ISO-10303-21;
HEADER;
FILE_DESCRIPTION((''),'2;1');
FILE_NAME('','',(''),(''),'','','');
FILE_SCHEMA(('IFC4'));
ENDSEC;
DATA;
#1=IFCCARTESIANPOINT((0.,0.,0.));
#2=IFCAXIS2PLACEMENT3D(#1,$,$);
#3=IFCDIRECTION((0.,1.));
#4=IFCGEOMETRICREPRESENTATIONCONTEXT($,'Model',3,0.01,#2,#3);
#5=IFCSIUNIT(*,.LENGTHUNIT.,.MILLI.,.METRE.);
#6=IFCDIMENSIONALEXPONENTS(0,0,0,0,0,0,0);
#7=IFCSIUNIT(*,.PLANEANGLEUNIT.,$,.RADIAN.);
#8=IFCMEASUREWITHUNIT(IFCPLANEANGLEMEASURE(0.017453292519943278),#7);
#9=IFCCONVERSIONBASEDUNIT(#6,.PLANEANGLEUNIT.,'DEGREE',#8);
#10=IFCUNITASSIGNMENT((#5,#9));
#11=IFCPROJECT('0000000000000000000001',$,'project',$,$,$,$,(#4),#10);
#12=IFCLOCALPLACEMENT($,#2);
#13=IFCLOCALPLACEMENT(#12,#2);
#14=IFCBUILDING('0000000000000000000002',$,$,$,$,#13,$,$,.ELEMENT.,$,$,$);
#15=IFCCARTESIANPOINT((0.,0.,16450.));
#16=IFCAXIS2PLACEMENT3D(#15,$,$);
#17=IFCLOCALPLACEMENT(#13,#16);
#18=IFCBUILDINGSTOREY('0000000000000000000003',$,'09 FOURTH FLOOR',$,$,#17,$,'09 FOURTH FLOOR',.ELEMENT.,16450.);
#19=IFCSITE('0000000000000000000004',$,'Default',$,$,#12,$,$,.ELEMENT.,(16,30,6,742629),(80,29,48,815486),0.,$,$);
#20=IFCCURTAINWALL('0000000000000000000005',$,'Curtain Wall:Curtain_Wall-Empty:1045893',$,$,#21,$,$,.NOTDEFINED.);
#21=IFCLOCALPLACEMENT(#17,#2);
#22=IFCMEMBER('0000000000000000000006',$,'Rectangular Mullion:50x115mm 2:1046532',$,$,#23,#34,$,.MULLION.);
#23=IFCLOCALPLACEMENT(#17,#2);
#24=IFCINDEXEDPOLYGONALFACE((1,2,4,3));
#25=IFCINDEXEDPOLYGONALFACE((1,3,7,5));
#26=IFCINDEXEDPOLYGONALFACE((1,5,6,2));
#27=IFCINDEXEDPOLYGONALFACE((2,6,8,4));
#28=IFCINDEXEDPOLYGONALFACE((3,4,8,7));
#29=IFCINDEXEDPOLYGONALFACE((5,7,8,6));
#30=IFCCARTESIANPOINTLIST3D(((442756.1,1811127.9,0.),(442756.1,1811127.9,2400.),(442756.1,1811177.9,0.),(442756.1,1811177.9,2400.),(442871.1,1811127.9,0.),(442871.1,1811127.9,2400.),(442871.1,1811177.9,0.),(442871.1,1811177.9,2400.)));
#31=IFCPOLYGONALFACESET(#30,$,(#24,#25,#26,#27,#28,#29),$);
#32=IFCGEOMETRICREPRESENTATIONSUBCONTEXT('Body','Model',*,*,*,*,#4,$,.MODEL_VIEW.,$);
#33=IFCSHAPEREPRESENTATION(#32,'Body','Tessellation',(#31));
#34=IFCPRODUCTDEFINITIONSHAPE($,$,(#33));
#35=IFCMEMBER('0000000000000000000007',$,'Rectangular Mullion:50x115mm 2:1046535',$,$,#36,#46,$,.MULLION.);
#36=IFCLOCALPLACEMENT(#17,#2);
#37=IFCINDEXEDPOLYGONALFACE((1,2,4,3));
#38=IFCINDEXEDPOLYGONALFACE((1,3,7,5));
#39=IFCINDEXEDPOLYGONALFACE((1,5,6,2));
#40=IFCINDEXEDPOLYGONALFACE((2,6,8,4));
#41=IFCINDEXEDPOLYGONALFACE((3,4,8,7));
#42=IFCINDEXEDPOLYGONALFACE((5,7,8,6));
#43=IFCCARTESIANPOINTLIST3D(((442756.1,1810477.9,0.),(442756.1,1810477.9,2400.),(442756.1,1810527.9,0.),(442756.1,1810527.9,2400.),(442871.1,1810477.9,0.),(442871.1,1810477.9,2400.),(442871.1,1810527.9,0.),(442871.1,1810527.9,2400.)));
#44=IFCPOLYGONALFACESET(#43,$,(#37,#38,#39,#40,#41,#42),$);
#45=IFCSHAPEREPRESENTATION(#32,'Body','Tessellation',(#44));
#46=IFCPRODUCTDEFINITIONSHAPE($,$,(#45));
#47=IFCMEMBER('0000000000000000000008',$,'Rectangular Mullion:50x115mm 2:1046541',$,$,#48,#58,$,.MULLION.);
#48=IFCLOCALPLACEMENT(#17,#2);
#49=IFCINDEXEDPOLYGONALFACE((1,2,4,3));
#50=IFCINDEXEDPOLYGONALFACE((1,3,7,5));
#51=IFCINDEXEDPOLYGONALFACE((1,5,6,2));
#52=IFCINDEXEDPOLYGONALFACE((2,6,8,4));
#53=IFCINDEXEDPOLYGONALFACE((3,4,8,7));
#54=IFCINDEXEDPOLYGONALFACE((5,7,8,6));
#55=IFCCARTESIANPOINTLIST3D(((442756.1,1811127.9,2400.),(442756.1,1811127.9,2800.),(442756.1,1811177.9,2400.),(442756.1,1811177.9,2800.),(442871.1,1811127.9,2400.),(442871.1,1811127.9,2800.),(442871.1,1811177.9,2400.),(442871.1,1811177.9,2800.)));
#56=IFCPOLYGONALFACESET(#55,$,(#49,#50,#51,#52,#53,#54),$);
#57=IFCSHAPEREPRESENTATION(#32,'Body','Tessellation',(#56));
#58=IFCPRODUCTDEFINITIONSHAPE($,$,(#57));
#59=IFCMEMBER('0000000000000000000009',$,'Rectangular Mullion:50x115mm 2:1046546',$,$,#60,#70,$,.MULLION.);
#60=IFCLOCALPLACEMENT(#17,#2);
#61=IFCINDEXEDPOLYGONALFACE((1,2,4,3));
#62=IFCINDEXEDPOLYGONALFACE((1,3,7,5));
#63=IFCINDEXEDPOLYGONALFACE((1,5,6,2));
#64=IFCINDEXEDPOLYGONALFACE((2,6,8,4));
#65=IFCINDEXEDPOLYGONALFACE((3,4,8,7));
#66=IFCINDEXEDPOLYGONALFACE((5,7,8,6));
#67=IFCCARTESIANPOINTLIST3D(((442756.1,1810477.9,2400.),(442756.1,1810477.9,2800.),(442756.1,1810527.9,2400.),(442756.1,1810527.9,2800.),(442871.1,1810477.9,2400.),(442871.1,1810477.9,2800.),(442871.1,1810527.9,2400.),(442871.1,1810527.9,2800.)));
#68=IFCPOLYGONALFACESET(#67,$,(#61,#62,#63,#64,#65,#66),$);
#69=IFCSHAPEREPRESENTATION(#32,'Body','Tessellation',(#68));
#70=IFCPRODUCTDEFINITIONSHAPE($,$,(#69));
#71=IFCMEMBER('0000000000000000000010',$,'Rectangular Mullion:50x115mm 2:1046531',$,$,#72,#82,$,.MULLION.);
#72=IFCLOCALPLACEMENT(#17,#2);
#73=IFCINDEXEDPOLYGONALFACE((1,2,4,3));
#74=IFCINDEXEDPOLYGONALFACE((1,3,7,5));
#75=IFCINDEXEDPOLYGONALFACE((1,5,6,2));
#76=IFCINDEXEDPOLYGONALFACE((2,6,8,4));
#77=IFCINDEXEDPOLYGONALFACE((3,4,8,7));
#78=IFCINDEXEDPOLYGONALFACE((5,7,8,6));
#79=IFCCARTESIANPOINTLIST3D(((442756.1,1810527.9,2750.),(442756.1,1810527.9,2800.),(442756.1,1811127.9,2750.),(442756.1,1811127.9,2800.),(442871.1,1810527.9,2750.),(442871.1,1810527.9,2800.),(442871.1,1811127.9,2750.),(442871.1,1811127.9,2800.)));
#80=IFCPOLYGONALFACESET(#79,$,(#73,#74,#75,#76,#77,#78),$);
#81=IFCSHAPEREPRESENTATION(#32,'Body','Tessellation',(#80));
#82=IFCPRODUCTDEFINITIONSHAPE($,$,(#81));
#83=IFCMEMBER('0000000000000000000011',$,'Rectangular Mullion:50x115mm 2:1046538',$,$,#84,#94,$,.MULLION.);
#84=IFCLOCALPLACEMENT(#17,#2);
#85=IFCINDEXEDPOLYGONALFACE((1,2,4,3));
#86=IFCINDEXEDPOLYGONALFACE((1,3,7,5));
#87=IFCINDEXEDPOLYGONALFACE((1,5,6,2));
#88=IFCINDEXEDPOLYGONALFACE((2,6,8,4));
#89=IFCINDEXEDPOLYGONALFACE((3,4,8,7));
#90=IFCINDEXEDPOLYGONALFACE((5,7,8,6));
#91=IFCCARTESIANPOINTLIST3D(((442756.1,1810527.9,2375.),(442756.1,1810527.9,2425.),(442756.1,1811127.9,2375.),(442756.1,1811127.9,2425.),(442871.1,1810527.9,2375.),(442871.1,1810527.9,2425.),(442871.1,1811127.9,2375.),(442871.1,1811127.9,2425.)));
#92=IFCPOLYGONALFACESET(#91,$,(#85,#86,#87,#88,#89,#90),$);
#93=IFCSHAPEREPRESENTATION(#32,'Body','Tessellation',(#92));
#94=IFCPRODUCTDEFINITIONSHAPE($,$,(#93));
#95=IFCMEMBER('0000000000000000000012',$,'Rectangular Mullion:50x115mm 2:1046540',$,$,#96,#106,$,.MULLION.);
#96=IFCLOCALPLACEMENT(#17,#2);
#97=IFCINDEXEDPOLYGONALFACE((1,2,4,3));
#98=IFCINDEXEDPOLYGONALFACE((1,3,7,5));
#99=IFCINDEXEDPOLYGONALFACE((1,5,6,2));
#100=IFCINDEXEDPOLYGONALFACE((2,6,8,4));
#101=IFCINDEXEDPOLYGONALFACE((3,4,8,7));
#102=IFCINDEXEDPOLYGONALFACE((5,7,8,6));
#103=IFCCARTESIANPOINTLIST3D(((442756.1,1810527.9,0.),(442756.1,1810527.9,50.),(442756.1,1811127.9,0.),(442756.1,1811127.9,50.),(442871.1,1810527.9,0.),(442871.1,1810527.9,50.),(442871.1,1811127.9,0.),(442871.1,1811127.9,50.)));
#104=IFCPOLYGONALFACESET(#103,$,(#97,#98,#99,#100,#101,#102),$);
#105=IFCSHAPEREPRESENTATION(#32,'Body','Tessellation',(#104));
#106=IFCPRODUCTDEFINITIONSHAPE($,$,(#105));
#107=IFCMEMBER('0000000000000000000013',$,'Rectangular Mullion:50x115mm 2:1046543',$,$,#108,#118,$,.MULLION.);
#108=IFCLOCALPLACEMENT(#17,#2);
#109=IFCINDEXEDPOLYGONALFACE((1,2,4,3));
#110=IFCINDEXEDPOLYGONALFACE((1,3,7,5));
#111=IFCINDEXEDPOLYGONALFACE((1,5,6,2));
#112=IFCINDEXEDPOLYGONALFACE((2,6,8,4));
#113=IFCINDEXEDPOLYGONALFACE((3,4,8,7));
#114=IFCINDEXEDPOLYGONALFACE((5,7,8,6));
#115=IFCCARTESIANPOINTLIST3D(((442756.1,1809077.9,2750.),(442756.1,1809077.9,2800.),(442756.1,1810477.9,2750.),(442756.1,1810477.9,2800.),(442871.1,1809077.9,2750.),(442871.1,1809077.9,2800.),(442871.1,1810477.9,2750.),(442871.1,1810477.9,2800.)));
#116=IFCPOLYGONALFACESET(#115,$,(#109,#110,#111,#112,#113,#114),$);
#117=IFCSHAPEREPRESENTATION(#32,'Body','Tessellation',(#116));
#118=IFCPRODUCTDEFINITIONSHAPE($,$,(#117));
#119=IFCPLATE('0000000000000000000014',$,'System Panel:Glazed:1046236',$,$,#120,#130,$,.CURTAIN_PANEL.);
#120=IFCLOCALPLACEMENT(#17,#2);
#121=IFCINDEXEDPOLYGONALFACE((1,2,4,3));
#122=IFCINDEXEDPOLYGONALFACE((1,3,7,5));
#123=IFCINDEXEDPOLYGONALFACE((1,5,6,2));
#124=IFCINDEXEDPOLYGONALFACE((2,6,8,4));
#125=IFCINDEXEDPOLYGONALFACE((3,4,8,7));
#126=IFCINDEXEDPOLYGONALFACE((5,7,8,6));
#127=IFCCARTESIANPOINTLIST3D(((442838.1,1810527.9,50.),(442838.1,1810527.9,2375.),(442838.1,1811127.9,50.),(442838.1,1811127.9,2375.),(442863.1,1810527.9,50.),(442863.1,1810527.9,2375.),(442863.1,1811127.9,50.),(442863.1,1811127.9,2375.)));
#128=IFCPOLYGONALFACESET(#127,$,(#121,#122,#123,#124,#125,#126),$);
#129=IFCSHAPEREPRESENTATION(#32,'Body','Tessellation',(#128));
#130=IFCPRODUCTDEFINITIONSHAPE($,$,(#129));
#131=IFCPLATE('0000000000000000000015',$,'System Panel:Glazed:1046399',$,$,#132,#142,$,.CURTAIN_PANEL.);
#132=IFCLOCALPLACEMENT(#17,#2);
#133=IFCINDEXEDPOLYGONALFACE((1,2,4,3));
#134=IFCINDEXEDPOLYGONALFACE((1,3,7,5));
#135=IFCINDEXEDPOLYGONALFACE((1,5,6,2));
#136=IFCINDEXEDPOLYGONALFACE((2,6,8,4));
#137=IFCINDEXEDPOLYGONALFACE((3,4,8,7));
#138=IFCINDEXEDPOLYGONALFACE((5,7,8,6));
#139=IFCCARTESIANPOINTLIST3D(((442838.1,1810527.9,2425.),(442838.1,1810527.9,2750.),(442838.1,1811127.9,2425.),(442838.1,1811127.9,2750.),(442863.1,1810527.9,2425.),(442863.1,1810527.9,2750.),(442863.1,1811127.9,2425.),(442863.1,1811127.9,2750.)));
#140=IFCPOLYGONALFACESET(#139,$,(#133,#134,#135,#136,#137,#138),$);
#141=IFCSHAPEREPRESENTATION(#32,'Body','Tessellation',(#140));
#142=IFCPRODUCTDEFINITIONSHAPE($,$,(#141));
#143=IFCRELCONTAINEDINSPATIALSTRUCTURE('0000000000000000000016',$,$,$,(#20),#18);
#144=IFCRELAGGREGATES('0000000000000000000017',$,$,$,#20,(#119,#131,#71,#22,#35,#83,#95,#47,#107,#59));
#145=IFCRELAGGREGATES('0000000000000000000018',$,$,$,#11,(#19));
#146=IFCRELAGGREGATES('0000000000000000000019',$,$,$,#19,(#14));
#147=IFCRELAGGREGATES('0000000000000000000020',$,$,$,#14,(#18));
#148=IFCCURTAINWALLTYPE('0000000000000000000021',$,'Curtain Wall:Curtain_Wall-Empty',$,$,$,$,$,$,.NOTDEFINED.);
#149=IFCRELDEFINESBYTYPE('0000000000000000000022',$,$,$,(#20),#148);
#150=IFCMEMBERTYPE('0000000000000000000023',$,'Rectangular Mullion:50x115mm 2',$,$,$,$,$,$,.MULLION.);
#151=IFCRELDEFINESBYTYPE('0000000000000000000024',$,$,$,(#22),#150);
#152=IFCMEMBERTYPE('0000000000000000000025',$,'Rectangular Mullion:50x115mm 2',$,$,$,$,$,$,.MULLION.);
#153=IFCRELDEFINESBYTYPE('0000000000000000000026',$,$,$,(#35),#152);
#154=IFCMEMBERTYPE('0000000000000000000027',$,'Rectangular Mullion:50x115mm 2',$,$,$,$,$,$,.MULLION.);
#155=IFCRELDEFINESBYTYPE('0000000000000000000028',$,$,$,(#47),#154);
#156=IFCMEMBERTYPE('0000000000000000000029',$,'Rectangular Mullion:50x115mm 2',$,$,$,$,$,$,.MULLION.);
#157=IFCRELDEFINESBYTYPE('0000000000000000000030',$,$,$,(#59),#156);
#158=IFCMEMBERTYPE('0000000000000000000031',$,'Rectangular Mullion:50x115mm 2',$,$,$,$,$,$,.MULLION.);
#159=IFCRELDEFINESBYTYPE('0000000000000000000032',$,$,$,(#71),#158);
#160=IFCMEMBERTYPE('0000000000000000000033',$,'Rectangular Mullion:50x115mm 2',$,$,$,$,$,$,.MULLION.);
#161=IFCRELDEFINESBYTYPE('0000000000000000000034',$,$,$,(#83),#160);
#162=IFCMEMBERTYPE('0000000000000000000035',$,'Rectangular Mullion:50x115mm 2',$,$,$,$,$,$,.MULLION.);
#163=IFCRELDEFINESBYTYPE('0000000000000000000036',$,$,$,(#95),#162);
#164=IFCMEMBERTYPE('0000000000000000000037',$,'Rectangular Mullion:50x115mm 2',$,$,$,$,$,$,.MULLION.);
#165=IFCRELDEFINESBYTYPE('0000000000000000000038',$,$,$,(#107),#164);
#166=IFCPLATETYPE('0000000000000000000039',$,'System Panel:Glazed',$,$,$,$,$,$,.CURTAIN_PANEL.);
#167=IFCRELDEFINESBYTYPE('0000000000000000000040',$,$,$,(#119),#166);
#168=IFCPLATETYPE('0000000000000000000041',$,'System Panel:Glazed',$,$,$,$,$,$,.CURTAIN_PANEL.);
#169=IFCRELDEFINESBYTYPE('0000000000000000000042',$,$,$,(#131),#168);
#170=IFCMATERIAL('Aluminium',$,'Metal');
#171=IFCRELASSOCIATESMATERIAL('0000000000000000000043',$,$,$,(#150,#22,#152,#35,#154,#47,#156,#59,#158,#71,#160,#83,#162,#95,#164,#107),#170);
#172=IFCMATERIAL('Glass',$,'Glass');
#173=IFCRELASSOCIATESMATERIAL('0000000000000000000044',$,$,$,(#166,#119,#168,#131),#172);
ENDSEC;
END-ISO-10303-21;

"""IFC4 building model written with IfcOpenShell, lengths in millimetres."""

from ifc_helpers import new_model, entity, si_unit, converted_unit, direction, frame, origin, place, context, subcontext, project, spatial, indexed_curve, outline, extrude, source, transform, mapped, material, type_object, type_shapes, element, aggregate, save


model = new_model("IFC4")

# Units and contexts
model_context = context("Model", 3, precision=0.01, world=origin(), true_north=direction((0.0, 1.0)))
body_context = subcontext(model_context, "Body", "Model", "MODEL_VIEW")
ifc_project = project(units=[si_unit("LENGTHUNIT", "METRE", prefix="MILLI"), converted_unit("PLANEANGLEUNIT", "DEGREE", entity("IfcPlaneAngleMeasure", 0.017453292519943278), si_unit("PLANEANGLEUNIT", "RADIAN"), dimensions=[0, 0, 0, 0, 0, 0, 0])], contexts=[model_context])

# Site, building, storey
site_placement = place(None, origin())
site = spatial("IfcSite", under=ifc_project, at=site_placement, Name="Default", CompositionType="ELEMENT", RefLatitude=(16, 30, 6, 742629), RefLongitude=(80, 29, 48, 815486), RefElevation=0.0)
building_placement = place(site_placement, origin())
building = spatial("IfcBuilding", under=site, at=building_placement, CompositionType="ELEMENT")
storey_placement = place(building_placement, frame((0.0, 0.0, 16450.0)))
storey = spatial("IfcBuildingStorey", under=building, at=storey_placement, Name="09 FOURTH FLOOR", LongName="09 FOURTH FLOOR", CompositionType="ELEMENT", Elevation=16450.0)

# Curtain wall, members, plates
curtain_wall_type = type_object("IfcCurtainWallType", Name="Curtain Wall:Curtain_Wall-Empty", PredefinedType="NOTDEFINED")
curtain_wall_placement = place(storey_placement, frame((0.0, 0.0, -16450.0)))
curtain_wall = element("IfcCurtainWall", 1, at=curtain_wall_placement, inside=storey, type_object=curtain_wall_type, Name="Curtain Wall:Curtain_Wall-Empty:1045893", PredefinedType="NOTDEFINED")
ifc_material_1 = material(Name="Aluminium", Category="Metal")
member_type_1 = type_object("IfcMemberType", Name="Rectangular Mullion:50x115mm 2", PredefinedType="MULLION", material=ifc_material_1)
shared_shape_1 = source(origin(), body_context, "Body", "SweptSolid", [
    extrude(outline(indexed_curve([(-25.0, -57.5), (25.0, -57.5), (25.0, 57.5), (-25.0, 57.5), (-25.0, -57.5)], self_intersect=False)), frame((-25.0, 0.0, -2400.0), z_axis=(0.0, 0.0, 1.0), x_axis=(-1.0, 0.0, 0.0)), (0.0, 0.0, 1.0), 2400.0),
])
type_shapes(member_type_1, [shared_shape_1])
member_1_placement = place(curtain_wall_placement, frame((442813.6, 1811177.9, 16450.0), z_axis=(0.0, 0.0, -1.0), x_axis=(0.0, 1.0, 0.0)))
member_1 = element("IfcMember", 2, at=member_1_placement, type_object=member_type_1, material=ifc_material_1, Name="Rectangular Mullion:50x115mm 2:1046532", PredefinedType="MULLION", context=body_context, shape_type="MappedRepresentation", body=[
    mapped(shared_shape_1, transform((0.0, 0.0, 0.0), scale=1.0)),
])
member_type_2 = type_object("IfcMemberType", Name="Rectangular Mullion:50x115mm 2", PredefinedType="MULLION", material=ifc_material_1)
shared_shape_2 = source(origin(), body_context, "Body", "SweptSolid", [
    extrude(outline(indexed_curve([(-25.0, -57.5), (25.0, -57.5), (25.0, 57.5), (-25.0, 57.5), (-25.0, -57.5)], self_intersect=False)), frame((0.0, 0.0, -2400.0), z_axis=(0.0, 0.0, 1.0), x_axis=(-1.0, 0.0, 0.0)), (0.0, 0.0, 1.0), 2400.0),
])
type_shapes(member_type_2, [shared_shape_2])
member_2_placement = place(curtain_wall_placement, frame((442813.6, 1810502.9, 16450.0), z_axis=(0.0, 0.0, -1.0), x_axis=(0.0, 1.0, 0.0)))
member_2 = element("IfcMember", 3, at=member_2_placement, type_object=member_type_2, material=ifc_material_1, Name="Rectangular Mullion:50x115mm 2:1046535", PredefinedType="MULLION", context=body_context, shape_type="MappedRepresentation", body=[
    mapped(shared_shape_2, transform((0.0, 0.0, 0.0), scale=1.0)),
])
member_type_3 = type_object("IfcMemberType", Name="Rectangular Mullion:50x115mm 2", PredefinedType="MULLION", material=ifc_material_1)
shared_shape_3 = source(origin(), body_context, "Body", "SweptSolid", [
    extrude(outline(indexed_curve([(-25.0, -57.5), (25.0, -57.5), (25.0, 57.5), (-25.0, 57.5), (-25.0, -57.5)], self_intersect=False)), frame((-25.0, 0.0, -400.0), z_axis=(0.0, 0.0, 1.0), x_axis=(-1.0, 0.0, 0.0)), (0.0, 0.0, 1.0), 400.0),
])
type_shapes(member_type_3, [shared_shape_3])
member_3_placement = place(curtain_wall_placement, frame((442813.6, 1811177.9, 18850.0), z_axis=(0.0, 0.0, -1.0), x_axis=(0.0, 1.0, 0.0)))
member_3 = element("IfcMember", 4, at=member_3_placement, type_object=member_type_3, material=ifc_material_1, Name="Rectangular Mullion:50x115mm 2:1046541", PredefinedType="MULLION", context=body_context, shape_type="MappedRepresentation", body=[
    mapped(shared_shape_3, transform((0.0, 0.0, 0.0), scale=1.0)),
])
member_type_4 = type_object("IfcMemberType", Name="Rectangular Mullion:50x115mm 2", PredefinedType="MULLION", material=ifc_material_1)
shared_shape_4 = source(origin(), body_context, "Body", "SweptSolid", [
    extrude(outline(indexed_curve([(-25.0, -57.5), (25.0, -57.5), (25.0, 57.5), (-25.0, 57.5), (-25.0, -57.5)], self_intersect=False)), frame((0.0, 0.0, -400.0), z_axis=(0.0, 0.0, 1.0), x_axis=(-1.0, 0.0, 0.0)), (0.0, 0.0, 1.0), 400.0),
])
type_shapes(member_type_4, [shared_shape_4])
member_4_placement = place(curtain_wall_placement, frame((442813.6, 1810502.9, 18850.0), z_axis=(0.0, 0.0, -1.0), x_axis=(0.0, 1.0, 0.0)))
member_4 = element("IfcMember", 5, at=member_4_placement, type_object=member_type_4, material=ifc_material_1, Name="Rectangular Mullion:50x115mm 2:1046546", PredefinedType="MULLION", context=body_context, shape_type="MappedRepresentation", body=[
    mapped(shared_shape_4, transform((0.0, 0.0, 0.0), scale=1.0)),
])
member_type_5 = type_object("IfcMemberType", Name="Rectangular Mullion:50x115mm 2", PredefinedType="MULLION", material=ifc_material_1)
shared_shape_5 = source(origin(), body_context, "Body", "SweptSolid", [
    extrude(outline(indexed_curve([(-25.0, -57.5), (25.0, -57.5), (25.0, 57.5), (-25.0, 57.5), (-25.0, -57.5)], self_intersect=False)), frame((-25.0, 0.0, -600.0), z_axis=(0.0, 0.0, 1.0), x_axis=(-1.0, 0.0, 0.0)), (0.0, 0.0, 1.0), 600.0),
])
type_shapes(member_type_5, [shared_shape_5])
member_5_placement = place(curtain_wall_placement, frame((442813.6, 1811127.9, 19250.0), z_axis=(0.0, 1.0, 0.0), x_axis=(0.0, 0.0, 1.0)))
member_5 = element("IfcMember", 6, at=member_5_placement, type_object=member_type_5, material=ifc_material_1, Name="Rectangular Mullion:50x115mm 2:1046531", PredefinedType="MULLION", context=body_context, shape_type="MappedRepresentation", body=[
    mapped(shared_shape_5, transform((0.0, 0.0, 0.0), scale=1.0)),
])
member_type_6 = type_object("IfcMemberType", Name="Rectangular Mullion:50x115mm 2", PredefinedType="MULLION", material=ifc_material_1)
shared_shape_6 = source(origin(), body_context, "Body", "SweptSolid", [
    extrude(outline(indexed_curve([(-25.0, -57.5), (25.0, -57.5), (25.0, 57.5), (-25.0, 57.5), (-25.0, -57.5)], self_intersect=False)), frame((0.0, 0.0, -600.0), z_axis=(0.0, 0.0, 1.0), x_axis=(-1.0, 0.0, 0.0)), (0.0, 0.0, 1.0), 600.0),
])
type_shapes(member_type_6, [shared_shape_6])
member_6_placement = place(curtain_wall_placement, frame((442813.6, 1811127.9, 18850.0), z_axis=(0.0, 1.0, 0.0), x_axis=(0.0, 0.0, 1.0)))
member_6 = element("IfcMember", 7, at=member_6_placement, type_object=member_type_6, material=ifc_material_1, Name="Rectangular Mullion:50x115mm 2:1046538", PredefinedType="MULLION", context=body_context, shape_type="MappedRepresentation", body=[
    mapped(shared_shape_6, transform((0.0, 0.0, 0.0), scale=1.0)),
])
member_type_7 = type_object("IfcMemberType", Name="Rectangular Mullion:50x115mm 2", PredefinedType="MULLION", material=ifc_material_1)
shared_shape_7 = source(origin(), body_context, "Body", "SweptSolid", [
    extrude(outline(indexed_curve([(-25.0, -57.5), (25.0, -57.5), (25.0, 57.5), (-25.0, 57.5), (-25.0, -57.5)], self_intersect=False)), frame((-25.0, 0.0, -600.0), z_axis=(0.0, 0.0, 1.0), x_axis=(-1.0, 0.0, 0.0)), (0.0, 0.0, 1.0), 600.0),
])
type_shapes(member_type_7, [shared_shape_7])
member_7_placement = place(curtain_wall_placement, frame((442813.6, 1810527.9, 16450.0), z_axis=(0.0, -1.0, 0.0), x_axis=(0.0, 0.0, -1.0)))
member_7 = element("IfcMember", 8, at=member_7_placement, type_object=member_type_7, material=ifc_material_1, Name="Rectangular Mullion:50x115mm 2:1046540", PredefinedType="MULLION", context=body_context, shape_type="MappedRepresentation", body=[
    mapped(shared_shape_7, transform((0.0, 0.0, 0.0), scale=1.0)),
])
member_type_8 = type_object("IfcMemberType", Name="Rectangular Mullion:50x115mm 2", PredefinedType="MULLION", material=ifc_material_1)
shared_shape_8 = source(origin(), body_context, "Body", "SweptSolid", [
    extrude(outline(indexed_curve([(-25.0, -57.5), (25.0, -57.5), (25.0, 57.5), (-25.0, 57.5), (-25.0, -57.5)], self_intersect=False)), frame((-25.0, 0.0, -1400.0), z_axis=(0.0, 0.0, 1.0), x_axis=(-1.0, 0.0, 0.0)), (0.0, 0.0, 1.0), 1400.0),
])
type_shapes(member_type_8, [shared_shape_8])
member_8_placement = place(curtain_wall_placement, frame((442813.6, 1810477.9, 19250.0), z_axis=(0.0, 1.0, 0.0), x_axis=(0.0, 0.0, 1.0)))
member_8 = element("IfcMember", 9, at=member_8_placement, type_object=member_type_8, material=ifc_material_1, Name="Rectangular Mullion:50x115mm 2:1046543", PredefinedType="MULLION", context=body_context, shape_type="MappedRepresentation", body=[
    mapped(shared_shape_8, transform((0.0, 0.0, 0.0), scale=1.0)),
])
ifc_material_2 = material(Name="Glass", Category="Glass")
plate_type_1 = type_object("IfcPlateType", Name="System Panel:Glazed", PredefinedType="CURTAIN_PANEL", material=ifc_material_2)
shared_shape_9 = source(origin(), body_context, "Body", "SweptSolid", [
    extrude(outline(indexed_curve([(-12.5, -300.0), (12.5, -300.0), (12.5, 300.0), (-12.5, 300.0), (-12.5, -300.0)], self_intersect=False)), frame((0.0, -37.0, 0.0), z_axis=(0.0, 0.0, 1.0), x_axis=(0.0, 1.0, 0.0)), (0.0, 0.0, 1.0), 2325.0),
])
type_shapes(plate_type_1, [shared_shape_9])
plate_1_placement = place(curtain_wall_placement, frame((442813.6, 1810827.9, 16500.0), z_axis=(0.0, 0.0, 1.0), x_axis=(0.0, 1.0, 0.0)))
plate_1 = element("IfcPlate", 10, at=plate_1_placement, type_object=plate_type_1, material=ifc_material_2, Name="System Panel:Glazed:1046236", PredefinedType="CURTAIN_PANEL", context=body_context, shape_type="MappedRepresentation", body=[
    mapped(shared_shape_9, transform((0.0, 0.0, 0.0), scale=1.0)),
])
plate_type_2 = type_object("IfcPlateType", Name="System Panel:Glazed", PredefinedType="CURTAIN_PANEL", material=ifc_material_2)
shared_shape_10 = source(origin(), body_context, "Body", "SweptSolid", [
    extrude(outline(indexed_curve([(-12.5, -300.0), (12.5, -300.0), (12.5, 300.0), (-12.5, 300.0), (-12.5, -300.0)], self_intersect=False)), frame((0.0, -37.0, 0.0), z_axis=(0.0, 0.0, 1.0), x_axis=(0.0, 1.0, 0.0)), (0.0, 0.0, 1.0), 325.0),
])
type_shapes(plate_type_2, [shared_shape_10])
plate_2_placement = place(curtain_wall_placement, frame((442813.6, 1810827.9, 18875.0), z_axis=(0.0, 0.0, 1.0), x_axis=(0.0, 1.0, 0.0)))
plate_2 = element("IfcPlate", 11, at=plate_2_placement, type_object=plate_type_2, material=ifc_material_2, Name="System Panel:Glazed:1046399", PredefinedType="CURTAIN_PANEL", context=body_context, shape_type="MappedRepresentation", body=[
    mapped(shared_shape_10, transform((0.0, 0.0, 0.0), scale=1.0)),
])
aggregate(curtain_wall, [plate_1, plate_2, member_5, member_1, member_2, member_6, member_7, member_3, member_8, member_4])

save(model, "model.ifc")
